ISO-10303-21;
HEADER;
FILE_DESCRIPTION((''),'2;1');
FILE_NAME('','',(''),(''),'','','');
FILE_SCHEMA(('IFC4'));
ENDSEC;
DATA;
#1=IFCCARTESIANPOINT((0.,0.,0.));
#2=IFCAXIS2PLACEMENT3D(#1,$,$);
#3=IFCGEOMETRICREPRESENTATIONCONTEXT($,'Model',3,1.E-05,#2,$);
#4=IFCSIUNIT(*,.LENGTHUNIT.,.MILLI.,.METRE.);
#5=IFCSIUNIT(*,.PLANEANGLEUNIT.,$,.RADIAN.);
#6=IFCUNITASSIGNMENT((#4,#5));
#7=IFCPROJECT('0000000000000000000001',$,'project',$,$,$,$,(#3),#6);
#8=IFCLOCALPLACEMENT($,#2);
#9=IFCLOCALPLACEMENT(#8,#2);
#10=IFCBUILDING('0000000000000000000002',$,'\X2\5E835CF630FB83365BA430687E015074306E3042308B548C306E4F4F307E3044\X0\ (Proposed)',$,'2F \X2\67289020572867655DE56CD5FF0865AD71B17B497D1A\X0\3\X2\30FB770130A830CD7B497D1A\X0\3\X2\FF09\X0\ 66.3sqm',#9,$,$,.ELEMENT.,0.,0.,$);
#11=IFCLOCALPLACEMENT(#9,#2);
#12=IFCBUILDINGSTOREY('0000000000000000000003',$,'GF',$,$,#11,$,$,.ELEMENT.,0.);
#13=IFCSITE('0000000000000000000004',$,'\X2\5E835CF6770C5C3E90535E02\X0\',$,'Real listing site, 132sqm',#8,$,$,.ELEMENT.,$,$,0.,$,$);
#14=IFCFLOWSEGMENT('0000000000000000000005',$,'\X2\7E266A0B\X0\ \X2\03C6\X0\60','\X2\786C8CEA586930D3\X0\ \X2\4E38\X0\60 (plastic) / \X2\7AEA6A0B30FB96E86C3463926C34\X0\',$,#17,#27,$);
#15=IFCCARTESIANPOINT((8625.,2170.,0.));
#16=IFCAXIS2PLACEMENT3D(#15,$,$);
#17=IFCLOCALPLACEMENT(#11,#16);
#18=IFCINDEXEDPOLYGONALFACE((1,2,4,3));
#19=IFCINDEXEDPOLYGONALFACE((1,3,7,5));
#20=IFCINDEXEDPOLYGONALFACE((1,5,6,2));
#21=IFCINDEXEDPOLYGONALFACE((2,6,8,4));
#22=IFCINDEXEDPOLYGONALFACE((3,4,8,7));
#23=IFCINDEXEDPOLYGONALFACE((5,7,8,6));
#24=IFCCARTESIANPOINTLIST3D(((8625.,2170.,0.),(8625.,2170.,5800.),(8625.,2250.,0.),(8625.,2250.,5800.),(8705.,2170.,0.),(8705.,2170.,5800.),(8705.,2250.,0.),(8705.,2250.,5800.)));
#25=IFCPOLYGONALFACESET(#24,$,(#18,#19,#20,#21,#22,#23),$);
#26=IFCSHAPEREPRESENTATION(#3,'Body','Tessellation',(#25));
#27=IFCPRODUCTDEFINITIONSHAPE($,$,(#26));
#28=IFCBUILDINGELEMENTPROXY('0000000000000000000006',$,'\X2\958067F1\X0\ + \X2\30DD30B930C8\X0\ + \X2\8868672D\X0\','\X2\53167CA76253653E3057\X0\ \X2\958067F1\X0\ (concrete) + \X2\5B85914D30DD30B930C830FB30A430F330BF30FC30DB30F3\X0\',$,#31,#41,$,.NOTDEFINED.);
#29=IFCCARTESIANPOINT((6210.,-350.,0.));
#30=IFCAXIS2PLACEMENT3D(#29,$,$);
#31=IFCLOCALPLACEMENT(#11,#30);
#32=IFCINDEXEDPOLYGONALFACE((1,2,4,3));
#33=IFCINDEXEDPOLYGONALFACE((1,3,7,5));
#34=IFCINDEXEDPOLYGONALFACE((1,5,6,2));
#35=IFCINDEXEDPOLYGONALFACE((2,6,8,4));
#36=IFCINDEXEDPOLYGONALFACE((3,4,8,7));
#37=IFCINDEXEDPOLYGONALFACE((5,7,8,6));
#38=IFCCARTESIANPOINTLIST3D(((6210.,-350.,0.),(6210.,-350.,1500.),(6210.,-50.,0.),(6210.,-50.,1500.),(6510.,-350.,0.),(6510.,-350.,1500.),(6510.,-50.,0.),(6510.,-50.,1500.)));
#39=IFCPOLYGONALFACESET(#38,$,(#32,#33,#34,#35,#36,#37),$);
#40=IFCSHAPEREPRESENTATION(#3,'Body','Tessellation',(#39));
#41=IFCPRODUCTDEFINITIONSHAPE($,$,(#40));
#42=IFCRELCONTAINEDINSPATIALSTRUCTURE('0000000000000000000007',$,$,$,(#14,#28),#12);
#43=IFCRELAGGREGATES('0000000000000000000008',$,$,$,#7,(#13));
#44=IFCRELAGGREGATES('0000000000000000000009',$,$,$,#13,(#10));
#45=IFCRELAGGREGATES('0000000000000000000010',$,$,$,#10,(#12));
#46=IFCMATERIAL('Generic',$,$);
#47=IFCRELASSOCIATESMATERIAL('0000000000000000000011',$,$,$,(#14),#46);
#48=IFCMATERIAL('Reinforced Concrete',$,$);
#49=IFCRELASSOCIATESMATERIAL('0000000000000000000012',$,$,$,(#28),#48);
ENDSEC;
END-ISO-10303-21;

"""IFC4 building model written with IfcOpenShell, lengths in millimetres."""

from ifc_helpers import new_model, si_unit, frame, frame_2d, origin, place, context, project, spatial, rectangle, extrude, material, element, save


model = new_model("IFC4")

# Units and contexts
model_context = context("Model", 3, precision=1e-05, world=origin())
ifc_project = project(units=[si_unit("LENGTHUNIT", "METRE", prefix="MILLI"), si_unit("PLANEANGLEUNIT", "RADIAN")], contexts=[model_context])

# Site, building, storey
site_placement = place(None, origin())
site = spatial("IfcSite", under=ifc_project, at=site_placement, Name="広島県尾道市", ObjectType="Real listing site, 132sqm", CompositionType="ELEMENT", RefElevation=0.0)
building_placement = place(site_placement, origin())
building = spatial("IfcBuilding", under=site, at=building_placement, Name="広島・茶室と縁側のある和の住まい (Proposed)", ObjectType="2F 木造在来工法（断熱等級3・省エネ等級3） 66.3sqm", CompositionType="ELEMENT", ElevationOfRefHeight=0.0, ElevationOfTerrain=0.0)
storey_placement = place(building_placement, origin())
storey = spatial("IfcBuildingStorey", under=building, at=storey_placement, Name="GF", CompositionType="ELEMENT", Elevation=0.0)

# Shared definitions
ifc_material_1 = material(Name="Generic")
ifc_material_2 = material(Name="Reinforced Concrete")

# Flow segment
flow_segment_placement = place(storey_placement, frame((8625.0, 2170.0, 0.0)))
element("IfcFlowSegment", 1, at=flow_segment_placement, inside=storey, material=ifc_material_1, Name="縦樋 φ60", Description="硬質塩ビ 丸60 (plastic) / 竪樋・雨水排水", context=model_context, shape_type="SweptSolid", body=[
    extrude(rectangle(XDim=80.0, YDim=80.0, at=frame_2d((40.0, 40.0))), frame((8625.0, 2170.0, 0.0)), (0.0, 0.0, 1.0), 5800.0),
])

# Building element proxy
proxy_placement = place(storey_placement, frame((6210.0, -350.0, 0.0)))
element("IfcBuildingElementProxy", 2, at=proxy_placement, inside=storey, material=ifc_material_2, Name="門柱 + ポスト + 表札", Description="化粧打放し 門柱 (concrete) + 宅配ポスト・インターホン", PredefinedType="NOTDEFINED", context=model_context, shape_type="SweptSolid", body=[
    extrude(rectangle(XDim=300.0, YDim=300.0, at=frame_2d((150.0, 150.0))), frame((6210.0, -350.0, 0.0)), (0.0, 0.0, 1.0), 1500.0),
])

save(model, "model.ifc")
